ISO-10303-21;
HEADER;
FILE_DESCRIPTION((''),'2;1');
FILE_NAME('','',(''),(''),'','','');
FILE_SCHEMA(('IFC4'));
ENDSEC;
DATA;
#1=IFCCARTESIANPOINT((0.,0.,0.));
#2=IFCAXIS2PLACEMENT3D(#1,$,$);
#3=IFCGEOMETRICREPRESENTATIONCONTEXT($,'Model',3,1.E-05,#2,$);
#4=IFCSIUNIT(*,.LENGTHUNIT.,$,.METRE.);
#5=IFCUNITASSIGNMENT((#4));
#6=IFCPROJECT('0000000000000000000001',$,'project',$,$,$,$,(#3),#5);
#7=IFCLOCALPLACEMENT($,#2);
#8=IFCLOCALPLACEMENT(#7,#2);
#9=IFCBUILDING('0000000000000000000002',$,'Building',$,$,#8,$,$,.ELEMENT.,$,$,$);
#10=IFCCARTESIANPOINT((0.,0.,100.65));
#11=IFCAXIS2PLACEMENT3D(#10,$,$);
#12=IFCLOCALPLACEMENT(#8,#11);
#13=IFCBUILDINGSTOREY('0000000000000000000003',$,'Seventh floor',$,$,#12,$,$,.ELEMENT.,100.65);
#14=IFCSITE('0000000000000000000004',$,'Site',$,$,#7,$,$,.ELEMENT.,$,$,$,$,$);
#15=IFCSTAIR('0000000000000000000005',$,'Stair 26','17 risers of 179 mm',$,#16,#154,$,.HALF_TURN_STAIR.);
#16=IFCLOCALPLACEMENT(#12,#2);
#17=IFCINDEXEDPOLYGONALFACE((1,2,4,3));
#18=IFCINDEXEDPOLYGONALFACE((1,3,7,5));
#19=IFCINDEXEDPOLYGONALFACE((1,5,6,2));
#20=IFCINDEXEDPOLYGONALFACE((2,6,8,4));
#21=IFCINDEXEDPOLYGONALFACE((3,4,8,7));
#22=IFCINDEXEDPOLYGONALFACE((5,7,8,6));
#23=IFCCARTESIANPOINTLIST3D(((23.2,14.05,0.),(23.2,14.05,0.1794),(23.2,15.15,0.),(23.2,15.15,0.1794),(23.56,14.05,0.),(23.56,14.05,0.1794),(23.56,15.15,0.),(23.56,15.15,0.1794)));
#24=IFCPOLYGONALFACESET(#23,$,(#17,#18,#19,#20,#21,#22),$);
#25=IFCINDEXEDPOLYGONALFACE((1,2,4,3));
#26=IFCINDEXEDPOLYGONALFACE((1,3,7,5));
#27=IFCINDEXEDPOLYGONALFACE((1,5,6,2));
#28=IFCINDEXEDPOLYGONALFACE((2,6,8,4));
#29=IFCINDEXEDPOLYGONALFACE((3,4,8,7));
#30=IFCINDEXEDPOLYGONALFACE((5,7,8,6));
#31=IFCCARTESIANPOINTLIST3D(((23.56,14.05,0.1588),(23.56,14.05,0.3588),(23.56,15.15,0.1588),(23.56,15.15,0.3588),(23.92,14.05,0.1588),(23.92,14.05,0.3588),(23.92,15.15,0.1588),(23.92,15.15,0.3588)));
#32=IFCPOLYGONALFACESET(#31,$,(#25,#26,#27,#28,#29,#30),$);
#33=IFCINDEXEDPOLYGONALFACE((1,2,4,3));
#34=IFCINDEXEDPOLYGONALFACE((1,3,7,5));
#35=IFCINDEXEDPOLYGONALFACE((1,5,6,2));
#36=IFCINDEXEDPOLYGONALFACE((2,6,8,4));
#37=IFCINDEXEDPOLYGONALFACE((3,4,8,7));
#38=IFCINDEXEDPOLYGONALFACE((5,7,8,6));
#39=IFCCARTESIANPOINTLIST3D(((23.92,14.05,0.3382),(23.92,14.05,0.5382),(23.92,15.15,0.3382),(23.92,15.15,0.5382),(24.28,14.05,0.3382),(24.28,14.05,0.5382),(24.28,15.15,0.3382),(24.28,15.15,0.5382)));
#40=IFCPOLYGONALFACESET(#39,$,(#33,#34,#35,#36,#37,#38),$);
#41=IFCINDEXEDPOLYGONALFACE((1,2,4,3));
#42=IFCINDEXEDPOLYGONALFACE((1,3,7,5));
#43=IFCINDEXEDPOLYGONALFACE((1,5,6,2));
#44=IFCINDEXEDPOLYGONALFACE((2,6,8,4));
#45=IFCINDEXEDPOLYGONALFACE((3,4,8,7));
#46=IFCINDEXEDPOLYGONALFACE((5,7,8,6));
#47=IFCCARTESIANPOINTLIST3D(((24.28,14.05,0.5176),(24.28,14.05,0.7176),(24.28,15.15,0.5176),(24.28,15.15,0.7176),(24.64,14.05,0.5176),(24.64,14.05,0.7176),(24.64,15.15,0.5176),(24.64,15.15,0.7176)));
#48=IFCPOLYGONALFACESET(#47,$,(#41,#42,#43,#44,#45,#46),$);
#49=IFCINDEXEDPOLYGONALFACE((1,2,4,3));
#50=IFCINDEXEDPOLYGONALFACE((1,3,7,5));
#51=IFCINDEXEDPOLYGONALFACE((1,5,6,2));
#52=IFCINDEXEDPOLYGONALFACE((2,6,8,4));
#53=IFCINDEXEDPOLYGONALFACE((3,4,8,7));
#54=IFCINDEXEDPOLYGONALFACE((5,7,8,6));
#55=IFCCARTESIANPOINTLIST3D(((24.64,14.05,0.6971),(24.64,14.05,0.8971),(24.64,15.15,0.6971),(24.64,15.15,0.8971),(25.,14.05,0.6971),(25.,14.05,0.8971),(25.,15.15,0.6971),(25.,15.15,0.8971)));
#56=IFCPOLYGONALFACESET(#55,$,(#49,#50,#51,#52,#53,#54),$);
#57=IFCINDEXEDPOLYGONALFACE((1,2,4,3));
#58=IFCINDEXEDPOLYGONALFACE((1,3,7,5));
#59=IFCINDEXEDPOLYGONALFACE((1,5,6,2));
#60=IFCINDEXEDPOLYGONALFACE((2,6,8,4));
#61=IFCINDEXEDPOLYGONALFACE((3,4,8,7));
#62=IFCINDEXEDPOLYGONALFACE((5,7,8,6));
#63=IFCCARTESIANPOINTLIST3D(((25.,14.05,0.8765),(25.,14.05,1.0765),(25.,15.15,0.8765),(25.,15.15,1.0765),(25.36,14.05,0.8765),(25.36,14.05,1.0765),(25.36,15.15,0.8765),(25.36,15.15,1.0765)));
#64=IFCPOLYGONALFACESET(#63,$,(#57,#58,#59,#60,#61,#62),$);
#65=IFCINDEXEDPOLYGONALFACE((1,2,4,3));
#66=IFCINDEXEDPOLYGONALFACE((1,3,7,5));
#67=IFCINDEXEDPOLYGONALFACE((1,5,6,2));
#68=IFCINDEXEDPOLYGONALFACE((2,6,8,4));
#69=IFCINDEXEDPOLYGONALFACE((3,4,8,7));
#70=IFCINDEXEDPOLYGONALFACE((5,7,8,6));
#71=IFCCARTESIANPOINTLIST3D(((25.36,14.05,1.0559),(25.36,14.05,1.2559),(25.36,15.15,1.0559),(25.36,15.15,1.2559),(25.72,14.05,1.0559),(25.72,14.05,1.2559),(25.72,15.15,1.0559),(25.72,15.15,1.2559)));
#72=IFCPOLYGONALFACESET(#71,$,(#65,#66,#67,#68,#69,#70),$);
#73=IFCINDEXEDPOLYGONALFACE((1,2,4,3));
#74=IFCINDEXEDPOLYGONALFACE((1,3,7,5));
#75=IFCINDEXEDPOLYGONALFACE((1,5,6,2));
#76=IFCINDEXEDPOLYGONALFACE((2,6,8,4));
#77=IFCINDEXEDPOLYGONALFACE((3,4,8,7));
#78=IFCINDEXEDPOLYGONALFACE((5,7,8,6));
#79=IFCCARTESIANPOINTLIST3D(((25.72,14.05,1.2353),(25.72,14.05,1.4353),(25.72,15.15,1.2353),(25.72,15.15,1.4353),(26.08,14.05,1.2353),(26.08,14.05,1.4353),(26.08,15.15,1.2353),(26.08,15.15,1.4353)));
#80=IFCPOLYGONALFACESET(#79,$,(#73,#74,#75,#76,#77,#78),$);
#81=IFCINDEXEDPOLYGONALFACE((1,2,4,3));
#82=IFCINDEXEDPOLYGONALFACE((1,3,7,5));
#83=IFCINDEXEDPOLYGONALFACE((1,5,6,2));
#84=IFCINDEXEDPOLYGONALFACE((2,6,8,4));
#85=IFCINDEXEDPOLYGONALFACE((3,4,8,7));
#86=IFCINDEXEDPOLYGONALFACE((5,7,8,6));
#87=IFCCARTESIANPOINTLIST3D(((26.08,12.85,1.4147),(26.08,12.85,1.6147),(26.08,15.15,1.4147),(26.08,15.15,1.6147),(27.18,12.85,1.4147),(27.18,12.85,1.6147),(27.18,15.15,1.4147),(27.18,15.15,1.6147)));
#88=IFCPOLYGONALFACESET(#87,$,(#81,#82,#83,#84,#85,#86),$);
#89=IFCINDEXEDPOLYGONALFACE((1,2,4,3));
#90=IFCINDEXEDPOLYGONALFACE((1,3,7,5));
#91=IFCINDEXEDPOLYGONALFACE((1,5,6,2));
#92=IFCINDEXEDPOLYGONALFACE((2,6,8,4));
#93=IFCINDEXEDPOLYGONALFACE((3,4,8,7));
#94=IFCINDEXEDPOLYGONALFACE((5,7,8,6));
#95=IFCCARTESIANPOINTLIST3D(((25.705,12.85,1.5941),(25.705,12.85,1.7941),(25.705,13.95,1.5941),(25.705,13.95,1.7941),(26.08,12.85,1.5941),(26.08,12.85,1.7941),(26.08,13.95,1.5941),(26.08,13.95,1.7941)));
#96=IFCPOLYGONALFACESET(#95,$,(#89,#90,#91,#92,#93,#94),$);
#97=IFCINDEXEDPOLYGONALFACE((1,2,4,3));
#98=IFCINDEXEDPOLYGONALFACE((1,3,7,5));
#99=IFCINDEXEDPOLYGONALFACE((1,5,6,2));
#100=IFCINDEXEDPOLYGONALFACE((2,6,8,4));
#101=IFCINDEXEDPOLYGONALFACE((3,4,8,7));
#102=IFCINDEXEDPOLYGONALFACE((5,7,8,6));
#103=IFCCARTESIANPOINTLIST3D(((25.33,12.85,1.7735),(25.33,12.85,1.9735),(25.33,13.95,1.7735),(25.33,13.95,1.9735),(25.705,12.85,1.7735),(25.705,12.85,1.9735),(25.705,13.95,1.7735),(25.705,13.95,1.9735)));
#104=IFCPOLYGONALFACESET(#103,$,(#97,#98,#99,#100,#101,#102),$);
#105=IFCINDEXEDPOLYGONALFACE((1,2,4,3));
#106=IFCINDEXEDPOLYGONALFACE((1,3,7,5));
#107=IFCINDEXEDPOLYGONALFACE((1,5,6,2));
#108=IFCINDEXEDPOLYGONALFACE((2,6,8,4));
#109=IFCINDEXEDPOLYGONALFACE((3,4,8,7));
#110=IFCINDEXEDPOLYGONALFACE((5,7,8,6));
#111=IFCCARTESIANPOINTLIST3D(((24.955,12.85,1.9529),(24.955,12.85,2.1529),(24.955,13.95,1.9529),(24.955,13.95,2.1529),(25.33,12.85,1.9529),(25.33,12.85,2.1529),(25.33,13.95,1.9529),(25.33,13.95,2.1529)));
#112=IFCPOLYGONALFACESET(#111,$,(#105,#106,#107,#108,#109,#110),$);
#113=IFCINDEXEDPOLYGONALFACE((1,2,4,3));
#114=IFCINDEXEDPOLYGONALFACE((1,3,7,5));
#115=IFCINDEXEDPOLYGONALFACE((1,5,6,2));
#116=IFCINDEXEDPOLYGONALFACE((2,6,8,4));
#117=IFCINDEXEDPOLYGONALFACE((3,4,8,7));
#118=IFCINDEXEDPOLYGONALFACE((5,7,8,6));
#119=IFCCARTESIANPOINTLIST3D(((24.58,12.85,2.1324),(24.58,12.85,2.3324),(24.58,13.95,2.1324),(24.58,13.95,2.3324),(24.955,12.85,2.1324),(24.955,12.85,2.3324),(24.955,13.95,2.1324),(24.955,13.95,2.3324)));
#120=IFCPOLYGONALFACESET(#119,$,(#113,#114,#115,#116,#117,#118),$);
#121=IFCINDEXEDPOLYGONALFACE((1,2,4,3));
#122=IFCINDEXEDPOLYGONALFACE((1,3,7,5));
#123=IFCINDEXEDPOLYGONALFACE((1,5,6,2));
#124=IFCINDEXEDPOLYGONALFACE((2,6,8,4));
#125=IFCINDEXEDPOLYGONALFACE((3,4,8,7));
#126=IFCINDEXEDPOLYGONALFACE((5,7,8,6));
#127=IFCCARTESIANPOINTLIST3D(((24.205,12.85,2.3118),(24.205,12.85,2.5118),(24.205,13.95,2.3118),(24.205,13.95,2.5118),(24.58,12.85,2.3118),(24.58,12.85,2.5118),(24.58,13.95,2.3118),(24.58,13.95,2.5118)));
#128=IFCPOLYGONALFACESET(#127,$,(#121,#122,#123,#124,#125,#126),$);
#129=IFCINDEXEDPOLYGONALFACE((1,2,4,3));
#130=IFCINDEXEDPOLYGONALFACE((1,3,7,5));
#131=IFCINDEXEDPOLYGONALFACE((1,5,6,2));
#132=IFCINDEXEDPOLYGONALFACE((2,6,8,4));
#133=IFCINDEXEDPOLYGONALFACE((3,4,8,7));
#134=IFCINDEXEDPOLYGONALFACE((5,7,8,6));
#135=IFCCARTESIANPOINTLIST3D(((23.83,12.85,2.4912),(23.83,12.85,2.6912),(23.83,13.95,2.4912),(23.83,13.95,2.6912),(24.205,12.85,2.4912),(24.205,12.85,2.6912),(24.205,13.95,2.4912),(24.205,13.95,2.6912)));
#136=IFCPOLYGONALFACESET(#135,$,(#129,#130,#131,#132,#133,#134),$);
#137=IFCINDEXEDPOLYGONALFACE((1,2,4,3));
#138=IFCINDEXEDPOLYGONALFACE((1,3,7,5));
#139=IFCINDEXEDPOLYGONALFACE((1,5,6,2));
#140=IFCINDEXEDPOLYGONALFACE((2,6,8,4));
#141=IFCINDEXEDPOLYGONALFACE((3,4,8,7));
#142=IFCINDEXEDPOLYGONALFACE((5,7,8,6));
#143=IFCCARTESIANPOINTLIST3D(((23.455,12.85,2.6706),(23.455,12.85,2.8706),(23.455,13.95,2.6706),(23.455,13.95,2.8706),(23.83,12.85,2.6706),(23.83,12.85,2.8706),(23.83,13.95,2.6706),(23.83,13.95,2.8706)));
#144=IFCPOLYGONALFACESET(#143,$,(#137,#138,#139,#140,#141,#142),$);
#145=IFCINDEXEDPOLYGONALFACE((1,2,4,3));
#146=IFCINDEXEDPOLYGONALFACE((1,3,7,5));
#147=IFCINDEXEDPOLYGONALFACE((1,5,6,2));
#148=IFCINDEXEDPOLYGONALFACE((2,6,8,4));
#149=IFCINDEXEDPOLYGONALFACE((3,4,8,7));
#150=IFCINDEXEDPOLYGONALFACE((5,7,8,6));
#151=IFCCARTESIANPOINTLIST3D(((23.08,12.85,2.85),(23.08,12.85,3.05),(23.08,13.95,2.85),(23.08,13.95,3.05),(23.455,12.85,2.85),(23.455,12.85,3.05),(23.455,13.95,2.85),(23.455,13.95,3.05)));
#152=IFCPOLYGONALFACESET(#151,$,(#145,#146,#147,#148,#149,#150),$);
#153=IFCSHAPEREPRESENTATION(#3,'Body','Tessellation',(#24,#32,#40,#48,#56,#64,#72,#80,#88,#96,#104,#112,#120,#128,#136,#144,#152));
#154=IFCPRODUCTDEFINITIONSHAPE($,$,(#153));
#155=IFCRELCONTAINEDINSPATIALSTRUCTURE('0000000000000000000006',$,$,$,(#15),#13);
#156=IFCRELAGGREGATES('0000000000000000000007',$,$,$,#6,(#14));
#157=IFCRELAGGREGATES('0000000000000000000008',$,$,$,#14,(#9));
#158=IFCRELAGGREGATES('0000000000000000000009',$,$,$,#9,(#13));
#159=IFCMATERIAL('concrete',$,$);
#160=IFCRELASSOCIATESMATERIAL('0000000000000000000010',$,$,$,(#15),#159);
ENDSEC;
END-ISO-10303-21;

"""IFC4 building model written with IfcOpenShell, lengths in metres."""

from ifc_helpers import new_model, si_unit, frame, origin, place, context, project, spatial, polyline, outline, extrude, material, element, save


model = new_model("IFC4")

# Units and contexts
model_context = context("Model", 3, precision=1e-05, world=origin())
ifc_project = project(units=[si_unit("LENGTHUNIT", "METRE")], contexts=[model_context])

# Site, building, storey
site_placement = place(None, origin())
site = spatial("IfcSite", under=ifc_project, at=site_placement, Name="Site", CompositionType="ELEMENT")
building_placement = place(site_placement, origin())
building = spatial("IfcBuilding", under=site, at=building_placement, Name="Building", CompositionType="ELEMENT")
storey_placement = place(building_placement, frame((0.0, 0.0, 100.65)))
storey = spatial("IfcBuildingStorey", under=building, at=storey_placement, Name="Seventh floor", CompositionType="ELEMENT", Elevation=100.65)

# Shared definitions
ifc_material = material(Name="concrete")

# Stair
stair_placement = place(storey_placement, frame((23.2, 14.6, 0.0), z_axis=(0.0, 0.0, 1.0), x_axis=(1.0, 0.0, 0.0)))
element("IfcStair", 1, at=stair_placement, inside=storey, material=ifc_material, Name="Stair 26", Description="17 risers of 179 mm", PredefinedType="HALF_TURN_STAIR", context=model_context, shape_type="SweptSolid", body=[
    extrude(outline(polyline([(0.0, -0.55), (0.36, -0.55), (0.36, 0.55), (0.0, 0.55), (0.0, -0.55)])), origin(), (0.0, 0.0, 1.0), 0.1794),
    extrude(outline(polyline([(0.36, -0.55), (0.72, -0.55), (0.72, 0.55), (0.36, 0.55), (0.36, -0.55)])), frame((0.0, 0.0, 0.1588)), (0.0, 0.0, 1.0), 0.2),
    extrude(outline(polyline([(0.72, -0.55), (1.08, -0.55), (1.08, 0.55), (0.72, 0.55), (0.72, -0.55)])), frame((0.0, 0.0, 0.3382)), (0.0, 0.0, 1.0), 0.2),
    extrude(outline(polyline([(1.08, -0.55), (1.44, -0.55), (1.44, 0.55), (1.08, 0.55), (1.08, -0.55)])), frame((0.0, 0.0, 0.5176)), (0.0, 0.0, 1.0), 0.2),
    extrude(outline(polyline([(1.44, -0.55), (1.8, -0.55), (1.8, 0.55), (1.44, 0.55), (1.44, -0.55)])), frame((0.0, 0.0, 0.6971)), (0.0, 0.0, 1.0), 0.2),
    extrude(outline(polyline([(1.8, -0.55), (2.16, -0.55), (2.16, 0.55), (1.8, 0.55), (1.8, -0.55)])), frame((0.0, 0.0, 0.8765)), (0.0, 0.0, 1.0), 0.2),
    extrude(outline(polyline([(2.16, -0.55), (2.52, -0.55), (2.52, 0.55), (2.16, 0.55), (2.16, -0.55)])), frame((0.0, 0.0, 1.0559)), (0.0, 0.0, 1.0), 0.2),
    extrude(outline(polyline([(2.52, -0.55), (2.88, -0.55), (2.88, 0.55), (2.52, 0.55), (2.52, -0.55)])), frame((0.0, 0.0, 1.2353)), (0.0, 0.0, 1.0), 0.2),
    extrude(outline(polyline([(2.88, -1.75), (3.98, -1.75), (3.98, 0.55), (2.88, 0.55), (2.88, -1.75)])), frame((0.0, 0.0, 1.4147)), (0.0, 0.0, 1.0), 0.2),
    extrude(outline(polyline([(2.505, -1.75), (2.88, -1.75), (2.88, -0.65), (2.505, -0.65), (2.505, -1.75)])), frame((0.0, 0.0, 1.5941)), (0.0, 0.0, 1.0), 0.2),
    extrude(outline(polyline([(2.13, -1.75), (2.505, -1.75), (2.505, -0.65), (2.13, -0.65), (2.13, -1.75)])), frame((0.0, 0.0, 1.7735)), (0.0, 0.0, 1.0), 0.2),
    extrude(outline(polyline([(1.755, -1.75), (2.13, -1.75), (2.13, -0.65), (1.755, -0.65), (1.755, -1.75)])), frame((0.0, 0.0, 1.9529)), (0.0, 0.0, 1.0), 0.2),
    extrude(outline(polyline([(1.38, -1.75), (1.755, -1.75), (1.755, -0.65), (1.38, -0.65), (1.38, -1.75)])), frame((0.0, 0.0, 2.1324)), (0.0, 0.0, 1.0), 0.2),
    extrude(outline(polyline([(1.005, -1.75), (1.38, -1.75), (1.38, -0.65), (1.005, -0.65), (1.005, -1.75)])), frame((0.0, 0.0, 2.3118)), (0.0, 0.0, 1.0), 0.2),
    extrude(outline(polyline([(0.63, -1.75), (1.005, -1.75), (1.005, -0.65), (0.63, -0.65), (0.63, -1.75)])), frame((0.0, 0.0, 2.4912)), (0.0, 0.0, 1.0), 0.2),
    extrude(outline(polyline([(0.255, -1.75), (0.63, -1.75), (0.63, -0.65), (0.255, -0.65), (0.255, -1.75)])), frame((0.0, 0.0, 2.6706)), (0.0, 0.0, 1.0), 0.2),
    extrude(outline(polyline([(-0.12, -1.75), (0.255, -1.75), (0.255, -0.65), (-0.12, -0.65), (-0.12, -1.75)])), frame((0.0, 0.0, 2.85)), (0.0, 0.0, 1.0), 0.2),
])

save(model, "model.ifc")
